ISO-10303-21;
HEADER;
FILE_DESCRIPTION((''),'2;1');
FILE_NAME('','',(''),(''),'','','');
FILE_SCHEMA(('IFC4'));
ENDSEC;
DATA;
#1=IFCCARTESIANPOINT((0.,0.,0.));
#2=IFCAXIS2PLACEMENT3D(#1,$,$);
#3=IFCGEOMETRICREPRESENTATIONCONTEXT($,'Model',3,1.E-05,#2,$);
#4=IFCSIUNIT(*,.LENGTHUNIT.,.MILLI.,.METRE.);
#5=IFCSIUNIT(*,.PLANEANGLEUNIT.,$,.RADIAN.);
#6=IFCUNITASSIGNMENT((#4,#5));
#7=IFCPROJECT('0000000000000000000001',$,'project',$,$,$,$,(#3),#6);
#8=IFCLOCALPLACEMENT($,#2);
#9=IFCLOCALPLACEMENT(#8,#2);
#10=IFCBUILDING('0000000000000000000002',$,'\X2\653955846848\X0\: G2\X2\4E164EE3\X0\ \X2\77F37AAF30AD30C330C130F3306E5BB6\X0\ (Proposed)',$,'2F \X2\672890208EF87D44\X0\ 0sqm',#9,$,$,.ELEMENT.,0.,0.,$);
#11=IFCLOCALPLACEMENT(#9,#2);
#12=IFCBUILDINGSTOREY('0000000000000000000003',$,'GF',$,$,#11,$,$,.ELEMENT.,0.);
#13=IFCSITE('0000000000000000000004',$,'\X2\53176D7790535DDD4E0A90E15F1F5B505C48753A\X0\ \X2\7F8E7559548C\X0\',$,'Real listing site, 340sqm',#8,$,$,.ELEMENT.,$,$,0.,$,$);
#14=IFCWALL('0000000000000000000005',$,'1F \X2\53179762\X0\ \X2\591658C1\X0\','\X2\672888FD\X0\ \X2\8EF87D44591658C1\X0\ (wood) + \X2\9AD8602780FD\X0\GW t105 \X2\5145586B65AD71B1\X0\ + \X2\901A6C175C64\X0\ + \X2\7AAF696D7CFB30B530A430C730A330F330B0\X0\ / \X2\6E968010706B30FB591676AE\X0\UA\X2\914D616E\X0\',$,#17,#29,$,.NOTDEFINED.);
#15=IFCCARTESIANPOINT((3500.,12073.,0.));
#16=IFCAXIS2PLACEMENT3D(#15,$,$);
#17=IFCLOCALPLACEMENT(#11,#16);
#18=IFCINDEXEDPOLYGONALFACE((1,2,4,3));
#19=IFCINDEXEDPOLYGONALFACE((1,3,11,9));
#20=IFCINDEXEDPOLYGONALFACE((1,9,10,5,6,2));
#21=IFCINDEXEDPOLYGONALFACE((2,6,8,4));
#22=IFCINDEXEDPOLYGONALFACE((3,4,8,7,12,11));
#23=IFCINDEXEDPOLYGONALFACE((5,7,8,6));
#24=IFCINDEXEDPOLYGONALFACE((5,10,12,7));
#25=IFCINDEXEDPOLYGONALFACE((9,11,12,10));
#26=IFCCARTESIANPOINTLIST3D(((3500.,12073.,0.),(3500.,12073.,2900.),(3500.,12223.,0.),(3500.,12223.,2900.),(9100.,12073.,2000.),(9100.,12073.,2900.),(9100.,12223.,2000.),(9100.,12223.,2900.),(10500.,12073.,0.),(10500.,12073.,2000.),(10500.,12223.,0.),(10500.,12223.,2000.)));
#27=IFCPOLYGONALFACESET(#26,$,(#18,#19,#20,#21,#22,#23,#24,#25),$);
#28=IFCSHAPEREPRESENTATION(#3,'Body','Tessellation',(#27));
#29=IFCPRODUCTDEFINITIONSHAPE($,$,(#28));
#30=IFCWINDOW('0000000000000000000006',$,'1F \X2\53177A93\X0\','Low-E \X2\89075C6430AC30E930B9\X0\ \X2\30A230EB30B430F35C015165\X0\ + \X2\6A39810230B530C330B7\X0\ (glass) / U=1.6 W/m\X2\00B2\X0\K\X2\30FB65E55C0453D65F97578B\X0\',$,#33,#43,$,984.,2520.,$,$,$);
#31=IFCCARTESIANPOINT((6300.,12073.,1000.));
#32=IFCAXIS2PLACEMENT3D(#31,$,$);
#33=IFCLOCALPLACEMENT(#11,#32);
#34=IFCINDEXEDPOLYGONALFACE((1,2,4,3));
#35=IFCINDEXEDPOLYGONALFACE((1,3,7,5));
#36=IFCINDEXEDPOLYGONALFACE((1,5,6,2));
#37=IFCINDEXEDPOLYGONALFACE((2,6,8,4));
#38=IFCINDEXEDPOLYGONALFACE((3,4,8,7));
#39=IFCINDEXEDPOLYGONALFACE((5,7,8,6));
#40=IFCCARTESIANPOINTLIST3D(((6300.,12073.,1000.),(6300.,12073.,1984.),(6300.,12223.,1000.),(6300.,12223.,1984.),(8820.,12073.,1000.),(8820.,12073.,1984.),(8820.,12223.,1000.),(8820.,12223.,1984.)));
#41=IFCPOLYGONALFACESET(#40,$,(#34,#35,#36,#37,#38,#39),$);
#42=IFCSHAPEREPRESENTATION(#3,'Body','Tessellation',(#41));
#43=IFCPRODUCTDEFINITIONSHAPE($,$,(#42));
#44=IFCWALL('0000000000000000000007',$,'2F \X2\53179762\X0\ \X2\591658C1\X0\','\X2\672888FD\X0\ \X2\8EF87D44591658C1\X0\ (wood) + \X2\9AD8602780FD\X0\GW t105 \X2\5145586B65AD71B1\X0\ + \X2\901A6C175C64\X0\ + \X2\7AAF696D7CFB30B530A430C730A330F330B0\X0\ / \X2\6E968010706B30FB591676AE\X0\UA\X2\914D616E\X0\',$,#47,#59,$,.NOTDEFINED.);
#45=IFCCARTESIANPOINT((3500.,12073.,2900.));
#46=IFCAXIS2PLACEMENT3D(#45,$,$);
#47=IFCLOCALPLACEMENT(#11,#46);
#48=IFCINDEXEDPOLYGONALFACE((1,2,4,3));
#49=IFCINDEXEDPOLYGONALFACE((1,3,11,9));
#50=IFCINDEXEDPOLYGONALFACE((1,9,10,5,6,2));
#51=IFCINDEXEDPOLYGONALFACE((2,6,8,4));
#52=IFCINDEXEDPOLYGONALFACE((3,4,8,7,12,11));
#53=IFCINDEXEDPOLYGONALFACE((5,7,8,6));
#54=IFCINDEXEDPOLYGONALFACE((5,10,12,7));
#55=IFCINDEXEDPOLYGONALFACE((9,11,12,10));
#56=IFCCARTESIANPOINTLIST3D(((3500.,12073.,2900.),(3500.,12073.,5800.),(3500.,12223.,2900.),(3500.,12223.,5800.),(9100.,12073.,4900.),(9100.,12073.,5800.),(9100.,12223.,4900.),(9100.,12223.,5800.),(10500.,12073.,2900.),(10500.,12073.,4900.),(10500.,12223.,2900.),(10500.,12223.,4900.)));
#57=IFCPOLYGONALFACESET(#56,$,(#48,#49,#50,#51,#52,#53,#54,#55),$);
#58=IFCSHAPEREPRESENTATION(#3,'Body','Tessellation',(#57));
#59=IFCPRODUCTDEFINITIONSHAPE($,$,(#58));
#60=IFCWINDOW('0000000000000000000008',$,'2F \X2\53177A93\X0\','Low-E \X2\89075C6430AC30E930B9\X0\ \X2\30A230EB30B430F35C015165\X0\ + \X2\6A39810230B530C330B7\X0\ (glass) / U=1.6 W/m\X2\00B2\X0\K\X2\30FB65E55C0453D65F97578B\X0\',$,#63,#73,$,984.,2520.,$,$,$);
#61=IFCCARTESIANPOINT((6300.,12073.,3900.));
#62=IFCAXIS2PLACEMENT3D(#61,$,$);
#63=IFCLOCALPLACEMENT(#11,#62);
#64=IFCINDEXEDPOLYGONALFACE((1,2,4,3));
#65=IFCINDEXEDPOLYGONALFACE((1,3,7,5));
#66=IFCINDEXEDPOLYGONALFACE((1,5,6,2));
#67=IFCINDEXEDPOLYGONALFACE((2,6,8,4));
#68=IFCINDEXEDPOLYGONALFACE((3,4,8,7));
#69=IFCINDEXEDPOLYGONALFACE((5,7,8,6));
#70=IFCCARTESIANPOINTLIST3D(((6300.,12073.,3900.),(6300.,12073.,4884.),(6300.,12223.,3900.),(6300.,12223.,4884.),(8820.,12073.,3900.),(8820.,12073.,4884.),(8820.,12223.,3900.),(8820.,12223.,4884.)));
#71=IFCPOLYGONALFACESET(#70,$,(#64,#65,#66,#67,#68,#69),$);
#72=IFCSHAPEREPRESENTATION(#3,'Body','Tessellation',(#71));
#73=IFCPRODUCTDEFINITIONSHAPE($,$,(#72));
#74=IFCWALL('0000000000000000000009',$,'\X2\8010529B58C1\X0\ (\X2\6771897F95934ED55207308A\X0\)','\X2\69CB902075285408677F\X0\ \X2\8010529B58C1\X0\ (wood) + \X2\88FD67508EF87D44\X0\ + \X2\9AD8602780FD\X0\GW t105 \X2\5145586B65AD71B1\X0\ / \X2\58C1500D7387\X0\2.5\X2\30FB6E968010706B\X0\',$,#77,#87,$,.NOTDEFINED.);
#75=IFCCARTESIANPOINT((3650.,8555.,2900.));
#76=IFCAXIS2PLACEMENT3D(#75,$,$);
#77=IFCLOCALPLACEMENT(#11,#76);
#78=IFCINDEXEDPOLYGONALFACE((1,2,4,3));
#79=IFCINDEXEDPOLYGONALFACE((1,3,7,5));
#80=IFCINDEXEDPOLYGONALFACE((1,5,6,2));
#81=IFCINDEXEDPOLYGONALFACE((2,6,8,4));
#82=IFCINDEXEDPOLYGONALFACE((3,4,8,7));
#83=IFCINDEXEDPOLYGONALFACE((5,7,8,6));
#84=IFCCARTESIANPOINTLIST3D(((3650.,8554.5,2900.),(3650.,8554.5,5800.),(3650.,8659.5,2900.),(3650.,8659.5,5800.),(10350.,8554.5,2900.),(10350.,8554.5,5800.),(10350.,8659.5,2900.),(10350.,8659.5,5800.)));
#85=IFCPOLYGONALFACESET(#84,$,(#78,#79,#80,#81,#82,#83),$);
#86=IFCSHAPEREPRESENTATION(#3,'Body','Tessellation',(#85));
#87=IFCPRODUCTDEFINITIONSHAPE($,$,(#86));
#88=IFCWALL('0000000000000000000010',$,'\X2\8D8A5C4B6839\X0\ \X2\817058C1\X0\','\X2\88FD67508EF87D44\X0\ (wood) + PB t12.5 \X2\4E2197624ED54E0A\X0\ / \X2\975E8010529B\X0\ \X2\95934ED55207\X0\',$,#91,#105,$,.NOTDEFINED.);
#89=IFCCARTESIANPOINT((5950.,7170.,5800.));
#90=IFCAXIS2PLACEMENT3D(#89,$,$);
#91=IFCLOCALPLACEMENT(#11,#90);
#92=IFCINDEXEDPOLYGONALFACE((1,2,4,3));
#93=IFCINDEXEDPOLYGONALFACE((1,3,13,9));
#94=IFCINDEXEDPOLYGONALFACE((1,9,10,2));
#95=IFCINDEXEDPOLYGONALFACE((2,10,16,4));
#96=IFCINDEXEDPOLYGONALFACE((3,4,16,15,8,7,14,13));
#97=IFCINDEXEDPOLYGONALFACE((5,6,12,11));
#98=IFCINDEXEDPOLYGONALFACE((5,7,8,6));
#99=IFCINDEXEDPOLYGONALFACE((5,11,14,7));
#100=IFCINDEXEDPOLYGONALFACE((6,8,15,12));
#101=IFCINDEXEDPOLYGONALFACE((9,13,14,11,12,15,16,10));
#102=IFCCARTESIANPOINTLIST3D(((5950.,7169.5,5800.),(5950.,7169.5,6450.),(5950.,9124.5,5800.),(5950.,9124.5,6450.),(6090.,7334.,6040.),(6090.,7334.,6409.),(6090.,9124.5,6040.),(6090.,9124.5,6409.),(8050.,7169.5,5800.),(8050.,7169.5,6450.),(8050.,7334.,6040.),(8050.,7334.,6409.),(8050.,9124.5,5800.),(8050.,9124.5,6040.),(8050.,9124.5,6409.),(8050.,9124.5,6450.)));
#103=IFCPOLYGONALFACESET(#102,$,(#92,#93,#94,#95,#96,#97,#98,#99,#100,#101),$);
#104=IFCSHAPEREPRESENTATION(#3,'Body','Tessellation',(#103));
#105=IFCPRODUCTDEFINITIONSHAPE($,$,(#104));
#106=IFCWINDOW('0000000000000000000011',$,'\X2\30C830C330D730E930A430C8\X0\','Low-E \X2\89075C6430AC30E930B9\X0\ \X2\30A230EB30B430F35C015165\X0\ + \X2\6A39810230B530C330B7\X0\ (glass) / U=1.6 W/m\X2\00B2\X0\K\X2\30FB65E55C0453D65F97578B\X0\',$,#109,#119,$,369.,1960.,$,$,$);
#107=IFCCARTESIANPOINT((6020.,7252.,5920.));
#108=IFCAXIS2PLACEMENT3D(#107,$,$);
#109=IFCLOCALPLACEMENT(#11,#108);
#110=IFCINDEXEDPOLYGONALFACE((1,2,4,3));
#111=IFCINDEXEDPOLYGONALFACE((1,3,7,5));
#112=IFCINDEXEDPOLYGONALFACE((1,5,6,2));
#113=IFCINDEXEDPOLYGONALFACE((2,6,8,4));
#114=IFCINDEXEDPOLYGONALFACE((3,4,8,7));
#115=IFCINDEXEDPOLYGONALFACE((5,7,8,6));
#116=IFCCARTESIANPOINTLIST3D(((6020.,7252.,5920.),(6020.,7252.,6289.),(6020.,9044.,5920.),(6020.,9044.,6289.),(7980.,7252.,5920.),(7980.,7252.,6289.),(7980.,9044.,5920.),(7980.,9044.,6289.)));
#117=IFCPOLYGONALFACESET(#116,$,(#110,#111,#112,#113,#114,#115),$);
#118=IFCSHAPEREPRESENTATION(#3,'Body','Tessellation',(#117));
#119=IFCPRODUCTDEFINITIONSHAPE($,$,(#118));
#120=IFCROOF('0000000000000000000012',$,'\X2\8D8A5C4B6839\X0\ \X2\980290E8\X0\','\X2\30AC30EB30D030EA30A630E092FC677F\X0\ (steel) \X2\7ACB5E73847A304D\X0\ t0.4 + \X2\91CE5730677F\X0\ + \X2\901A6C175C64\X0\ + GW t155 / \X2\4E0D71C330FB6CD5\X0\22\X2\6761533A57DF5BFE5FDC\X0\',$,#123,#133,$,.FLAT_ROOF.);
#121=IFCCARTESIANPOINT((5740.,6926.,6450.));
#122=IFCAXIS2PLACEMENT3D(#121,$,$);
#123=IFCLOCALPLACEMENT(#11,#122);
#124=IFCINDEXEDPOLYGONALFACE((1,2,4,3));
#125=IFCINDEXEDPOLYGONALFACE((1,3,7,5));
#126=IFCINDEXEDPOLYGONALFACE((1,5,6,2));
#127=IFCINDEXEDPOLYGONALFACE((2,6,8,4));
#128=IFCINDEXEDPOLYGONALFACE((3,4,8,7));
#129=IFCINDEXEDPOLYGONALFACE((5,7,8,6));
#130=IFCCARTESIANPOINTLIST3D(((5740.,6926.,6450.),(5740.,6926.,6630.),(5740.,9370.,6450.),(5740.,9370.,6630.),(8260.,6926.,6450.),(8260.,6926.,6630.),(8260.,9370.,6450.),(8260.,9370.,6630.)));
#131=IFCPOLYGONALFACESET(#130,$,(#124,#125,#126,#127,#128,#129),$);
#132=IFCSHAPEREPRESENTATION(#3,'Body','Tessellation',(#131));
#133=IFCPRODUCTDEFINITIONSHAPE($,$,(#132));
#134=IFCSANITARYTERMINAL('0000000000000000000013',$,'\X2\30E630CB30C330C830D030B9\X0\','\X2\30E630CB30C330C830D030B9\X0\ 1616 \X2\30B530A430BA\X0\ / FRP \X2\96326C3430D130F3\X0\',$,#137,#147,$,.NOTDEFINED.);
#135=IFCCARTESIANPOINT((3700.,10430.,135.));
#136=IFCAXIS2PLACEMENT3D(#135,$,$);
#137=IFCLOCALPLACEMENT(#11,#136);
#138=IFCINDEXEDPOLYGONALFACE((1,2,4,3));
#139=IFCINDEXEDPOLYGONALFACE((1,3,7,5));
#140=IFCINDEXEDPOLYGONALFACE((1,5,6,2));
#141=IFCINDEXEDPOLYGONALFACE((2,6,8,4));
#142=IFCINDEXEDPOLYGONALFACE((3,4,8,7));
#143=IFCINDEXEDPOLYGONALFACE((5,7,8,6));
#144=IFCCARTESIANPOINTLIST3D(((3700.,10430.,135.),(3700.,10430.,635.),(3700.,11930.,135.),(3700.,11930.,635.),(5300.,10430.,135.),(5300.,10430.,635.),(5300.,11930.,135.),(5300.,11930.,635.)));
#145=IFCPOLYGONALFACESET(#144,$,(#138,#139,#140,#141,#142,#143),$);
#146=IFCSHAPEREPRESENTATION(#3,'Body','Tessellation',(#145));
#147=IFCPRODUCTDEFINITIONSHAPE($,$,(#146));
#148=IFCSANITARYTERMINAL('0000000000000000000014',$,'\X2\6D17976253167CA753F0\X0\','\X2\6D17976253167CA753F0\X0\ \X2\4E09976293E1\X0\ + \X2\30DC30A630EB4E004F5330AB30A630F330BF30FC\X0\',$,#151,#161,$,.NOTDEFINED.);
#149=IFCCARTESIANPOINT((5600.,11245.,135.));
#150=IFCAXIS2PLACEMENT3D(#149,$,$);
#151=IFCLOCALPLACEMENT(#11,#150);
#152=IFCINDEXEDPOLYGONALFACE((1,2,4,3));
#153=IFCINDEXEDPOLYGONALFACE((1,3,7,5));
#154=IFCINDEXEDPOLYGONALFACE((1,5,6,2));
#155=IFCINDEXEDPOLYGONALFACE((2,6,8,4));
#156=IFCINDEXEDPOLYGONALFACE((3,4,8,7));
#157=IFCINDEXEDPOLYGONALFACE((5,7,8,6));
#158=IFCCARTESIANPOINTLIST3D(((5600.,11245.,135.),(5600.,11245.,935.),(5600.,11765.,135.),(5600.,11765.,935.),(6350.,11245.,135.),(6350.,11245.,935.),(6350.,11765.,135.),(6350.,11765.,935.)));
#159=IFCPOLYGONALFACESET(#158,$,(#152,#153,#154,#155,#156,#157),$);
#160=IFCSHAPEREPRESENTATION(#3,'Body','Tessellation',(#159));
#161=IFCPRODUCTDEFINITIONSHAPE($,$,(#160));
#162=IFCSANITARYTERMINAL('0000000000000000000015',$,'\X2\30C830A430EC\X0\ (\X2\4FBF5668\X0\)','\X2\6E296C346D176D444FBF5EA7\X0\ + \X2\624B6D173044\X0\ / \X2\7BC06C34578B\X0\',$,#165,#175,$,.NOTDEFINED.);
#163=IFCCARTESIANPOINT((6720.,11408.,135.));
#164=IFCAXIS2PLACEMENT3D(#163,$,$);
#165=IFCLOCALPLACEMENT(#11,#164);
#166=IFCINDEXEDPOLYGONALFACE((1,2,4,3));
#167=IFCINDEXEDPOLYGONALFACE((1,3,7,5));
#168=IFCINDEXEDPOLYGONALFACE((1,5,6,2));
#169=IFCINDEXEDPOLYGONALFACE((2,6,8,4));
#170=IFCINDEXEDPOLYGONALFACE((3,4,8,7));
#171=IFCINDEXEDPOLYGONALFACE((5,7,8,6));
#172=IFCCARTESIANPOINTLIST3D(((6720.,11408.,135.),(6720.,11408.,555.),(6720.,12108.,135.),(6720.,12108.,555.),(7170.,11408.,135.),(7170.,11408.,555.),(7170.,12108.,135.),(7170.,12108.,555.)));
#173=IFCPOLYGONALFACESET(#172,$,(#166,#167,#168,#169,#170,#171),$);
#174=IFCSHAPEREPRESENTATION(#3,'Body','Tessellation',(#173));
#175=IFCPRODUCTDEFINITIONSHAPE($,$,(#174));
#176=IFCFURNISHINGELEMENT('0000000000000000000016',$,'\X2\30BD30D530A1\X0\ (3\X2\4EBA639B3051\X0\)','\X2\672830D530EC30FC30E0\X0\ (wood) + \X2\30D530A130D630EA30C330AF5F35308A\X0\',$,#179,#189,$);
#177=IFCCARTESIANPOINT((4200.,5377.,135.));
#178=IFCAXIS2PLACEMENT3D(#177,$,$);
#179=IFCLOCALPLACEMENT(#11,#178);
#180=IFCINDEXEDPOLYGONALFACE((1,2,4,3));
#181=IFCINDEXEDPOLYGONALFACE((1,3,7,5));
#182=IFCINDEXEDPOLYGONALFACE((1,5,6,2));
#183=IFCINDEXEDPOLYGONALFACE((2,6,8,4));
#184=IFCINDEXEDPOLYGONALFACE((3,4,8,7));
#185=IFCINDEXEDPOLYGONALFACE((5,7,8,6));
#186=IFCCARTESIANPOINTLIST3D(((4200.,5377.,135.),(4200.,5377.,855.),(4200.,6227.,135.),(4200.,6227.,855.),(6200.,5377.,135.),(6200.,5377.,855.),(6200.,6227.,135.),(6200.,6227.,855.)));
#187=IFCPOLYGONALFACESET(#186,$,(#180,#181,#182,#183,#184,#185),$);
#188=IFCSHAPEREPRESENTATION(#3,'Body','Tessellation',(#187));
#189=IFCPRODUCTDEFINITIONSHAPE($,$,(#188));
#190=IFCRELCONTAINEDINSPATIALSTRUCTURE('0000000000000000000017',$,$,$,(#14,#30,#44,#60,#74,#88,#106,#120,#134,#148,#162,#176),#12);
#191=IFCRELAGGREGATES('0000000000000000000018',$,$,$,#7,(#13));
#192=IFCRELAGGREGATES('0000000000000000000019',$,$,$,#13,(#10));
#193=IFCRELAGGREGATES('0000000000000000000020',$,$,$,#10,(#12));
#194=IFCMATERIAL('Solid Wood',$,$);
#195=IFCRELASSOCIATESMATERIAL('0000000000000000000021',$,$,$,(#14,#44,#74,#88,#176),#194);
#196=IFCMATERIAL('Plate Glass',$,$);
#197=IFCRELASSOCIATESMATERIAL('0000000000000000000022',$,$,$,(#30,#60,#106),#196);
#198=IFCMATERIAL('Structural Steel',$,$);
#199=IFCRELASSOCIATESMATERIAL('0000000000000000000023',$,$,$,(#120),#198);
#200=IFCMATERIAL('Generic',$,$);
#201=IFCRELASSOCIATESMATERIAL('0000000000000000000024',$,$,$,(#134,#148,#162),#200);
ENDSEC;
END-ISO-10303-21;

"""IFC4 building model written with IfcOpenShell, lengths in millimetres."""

from ifc_helpers import new_model, si_unit, frame, frame_2d, origin, place, context, project, spatial, rectangle, extrude, material, element, fill, save


model = new_model("IFC4")

# Units and contexts
model_context = context("Model", 3, precision=1e-05, world=origin())
ifc_project = project(units=[si_unit("LENGTHUNIT", "METRE", prefix="MILLI"), si_unit("PLANEANGLEUNIT", "RADIAN")], contexts=[model_context])

# Site, building, storey
site_placement = place(None, origin())
site = spatial("IfcSite", under=ifc_project, at=site_placement, Name="北海道川上郡弟子屈町 美留和", ObjectType="Real listing site, 340sqm", CompositionType="ELEMENT", RefElevation=0.0)
building_placement = place(site_placement, origin())
building = spatial("IfcBuilding", under=site, at=building_placement, Name="改善案: G2世代 石窯キッチンの家 (Proposed)", ObjectType="2F 木造軸組 0sqm", CompositionType="ELEMENT", ElevationOfRefHeight=0.0, ElevationOfTerrain=0.0)
storey_placement = place(building_placement, origin())
storey = spatial("IfcBuildingStorey", under=building, at=storey_placement, Name="GF", CompositionType="ELEMENT", Elevation=0.0)

# Wall, opening, window
ifc_material_1 = material(Name="Solid Wood")
wall_1_placement = place(storey_placement, frame((3500.0, 12073.0, 0.0)))
wall_1 = element("IfcWall", 1, at=wall_1_placement, inside=storey, material=ifc_material_1, Name="1F 北面 外壁", Description="木製 軸組外壁 (wood) + 高性能GW t105 充填断熱 + 通気層 + 窯業系サイディング / 準耐火・外皮UA配慮", PredefinedType="NOTDEFINED", context=model_context, shape_type="SweptSolid", body=[
    extrude(rectangle(XDim=7000.0, YDim=150.0, at=frame_2d((3500.0, 75.0))), frame((3500.0, 12073.0, 0.0)), (0.0, 0.0, 1.0), 2900.0),
])
opening_1_placement = place(storey_placement, frame((6300.0, 12073.0, 1000.0)))
opening_1 = element("IfcOpeningElement", 2, at=opening_1_placement, cuts=wall_1, PredefinedType="NOTDEFINED", context=model_context, shape_type="SweptSolid", body=[
    extrude(rectangle(XDim=2520.0, YDim=150.0, at=frame_2d((1260.0, 75.0))), frame((6300.0, 12073.0, 1000.0)), (0.0, 0.0, 1.0), 984.0),
])
ifc_material_2 = material(Name="Plate Glass")
window_1_placement = place(storey_placement, frame((6300.0, 12073.0, 1000.0)))
window_1 = element("IfcWindow", 3, at=window_1_placement, inside=storey, material=ifc_material_2, Name="1F 北窓", Description="Low-E 複層ガラス アルゴン封入 + 樹脂サッシ (glass) / U=1.6 W/m²K・日射取得型", OverallHeight=984.0, OverallWidth=2520.0, context=model_context, shape_type="SweptSolid", body=[
    extrude(rectangle(XDim=2520.0, YDim=150.0, at=frame_2d((1260.0, 75.0))), frame((6300.0, 12073.0, 1000.0)), (0.0, 0.0, 1.0), 984.0),
])
fill(opening_1, window_1)

# Wall, opening, window
wall_2_placement = place(storey_placement, frame((3500.0, 12073.0, 2900.0)))
wall_2 = element("IfcWall", 4, at=wall_2_placement, inside=storey, material=ifc_material_1, Name="2F 北面 外壁", Description="木製 軸組外壁 (wood) + 高性能GW t105 充填断熱 + 通気層 + 窯業系サイディング / 準耐火・外皮UA配慮", PredefinedType="NOTDEFINED", context=model_context, shape_type="SweptSolid", body=[
    extrude(rectangle(XDim=7000.0, YDim=150.0, at=frame_2d((3500.0, 75.0))), frame((3500.0, 12073.0, 2900.0)), (0.0, 0.0, 1.0), 2900.0),
])
opening_2_placement = place(storey_placement, frame((6300.0, 12073.0, 3900.0)))
opening_2 = element("IfcOpeningElement", 5, at=opening_2_placement, cuts=wall_2, PredefinedType="NOTDEFINED", context=model_context, shape_type="SweptSolid", body=[
    extrude(rectangle(XDim=2520.0, YDim=150.0, at=frame_2d((1260.0, 75.0))), frame((6300.0, 12073.0, 3900.0)), (0.0, 0.0, 1.0), 984.0),
])
window_2_placement = place(storey_placement, frame((6300.0, 12073.0, 3900.0)))
window_2 = element("IfcWindow", 6, at=window_2_placement, inside=storey, material=ifc_material_2, Name="2F 北窓", Description="Low-E 複層ガラス アルゴン封入 + 樹脂サッシ (glass) / U=1.6 W/m²K・日射取得型", OverallHeight=984.0, OverallWidth=2520.0, context=model_context, shape_type="SweptSolid", body=[
    extrude(rectangle(XDim=2520.0, YDim=150.0, at=frame_2d((1260.0, 75.0))), frame((6300.0, 12073.0, 3900.0)), (0.0, 0.0, 1.0), 984.0),
])
fill(opening_2, window_2)

# Wall
wall_3_placement = place(storey_placement, frame((3650.0, 8555.0, 2900.0)))
element("IfcWall", 7, at=wall_3_placement, inside=storey, material=ifc_material_1, Name="耐力壁 (東西間仕切り)", Description="構造用合板 耐力壁 (wood) + 製材軸組 + 高性能GW t105 充填断熱 / 壁倍率2.5・準耐火", PredefinedType="NOTDEFINED", context=model_context, shape_type="SweptSolid", body=[
    extrude(rectangle(XDim=6700.0, YDim=105.0, at=frame_2d((3350.0, 52.0))), frame((3650.0, 8555.0, 2900.0)), (0.0, 0.0, 1.0), 2900.0),
])

# Wall, opening, window
wall_4_placement = place(storey_placement, frame((5950.0, 7170.0, 5800.0)))
wall_4 = element("IfcWall", 8, at=wall_4_placement, inside=storey, material=ifc_material_1, Name="越屋根 腰壁", Description="製材軸組 (wood) + PB t12.5 両面仕上 / 非耐力 間仕切", PredefinedType="NOTDEFINED", context=model_context, shape_type="SweptSolid", body=[
    extrude(rectangle(XDim=2100.0, YDim=1955.0, at=frame_2d((1050.0, 977.0))), frame((5950.0, 7170.0, 5800.0)), (0.0, 0.0, 1.0), 650.0),
])
opening_3_placement = place(storey_placement, frame((6020.0, 7252.0, 5920.0)))
opening_3 = element("IfcOpeningElement", 9, at=opening_3_placement, cuts=wall_4, PredefinedType="NOTDEFINED", context=model_context, shape_type="SweptSolid", body=[
    extrude(rectangle(XDim=1960.0, YDim=1792.0, at=frame_2d((980.0, 896.0))), frame((6020.0, 7252.0, 5920.0)), (0.0, 0.0, 1.0), 369.0),
])
window_3_placement = place(storey_placement, frame((6020.0, 7252.0, 5920.0)))
window_3 = element("IfcWindow", 10, at=window_3_placement, inside=storey, material=ifc_material_2, Name="トップライト", Description="Low-E 複層ガラス アルゴン封入 + 樹脂サッシ (glass) / U=1.6 W/m²K・日射取得型", OverallHeight=369.0, OverallWidth=1960.0, context=model_context, shape_type="SweptSolid", body=[
    extrude(rectangle(XDim=1960.0, YDim=1792.0, at=frame_2d((980.0, 896.0))), frame((6020.0, 7252.0, 5920.0)), (0.0, 0.0, 1.0), 369.0),
])
fill(opening_3, window_3)

# Roof
ifc_material_3 = material(Name="Structural Steel")
roof_placement = place(storey_placement, frame((5740.0, 6926.0, 6450.0)))
element("IfcRoof", 11, at=roof_placement, inside=storey, material=ifc_material_3, Name="越屋根 頂部", Description="ガルバリウム鋼板 (steel) 立平葺き t0.4 + 野地板 + 通気層 + GW t155 / 不燃・法22条区域対応", PredefinedType="FLAT_ROOF", context=model_context, shape_type="SweptSolid", body=[
    extrude(rectangle(XDim=2520.0, YDim=2444.0, at=frame_2d((1260.0, 1222.0))), frame((5740.0, 6926.0, 6450.0)), (0.0, 0.0, 1.0), 180.0),
])

# Sanitary terminals
ifc_material_4 = material(Name="Generic")
sanitary_terminal_1_placement = place(storey_placement, frame((3700.0, 10430.0, 135.0)))
element("IfcSanitaryTerminal", 12, at=sanitary_terminal_1_placement, inside=storey, material=ifc_material_4, Name="ユニットバス", Description="ユニットバス 1616 サイズ / FRP 防水パン", PredefinedType="NOTDEFINED", context=model_context, shape_type="SweptSolid", body=[
    extrude(rectangle(XDim=1600.0, YDim=1500.0, at=frame_2d((800.0, 750.0))), frame((3700.0, 10430.0, 135.0)), (0.0, 0.0, 1.0), 500.0),
])
sanitary_terminal_2_placement = place(storey_placement, frame((5600.0, 11245.0, 135.0)))
element("IfcSanitaryTerminal", 13, at=sanitary_terminal_2_placement, inside=storey, material=ifc_material_4, Name="洗面化粧台", Description="洗面化粧台 三面鏡 + ボウル一体カウンター", PredefinedType="NOTDEFINED", context=model_context, shape_type="SweptSolid", body=[
    extrude(rectangle(XDim=750.0, YDim=520.0, at=frame_2d((375.0, 260.0))), frame((5600.0, 11245.0, 135.0)), (0.0, 0.0, 1.0), 800.0),
])
sanitary_terminal_3_placement = place(storey_placement, frame((6720.0, 11408.0, 135.0)))
element("IfcSanitaryTerminal", 14, at=sanitary_terminal_3_placement, inside=storey, material=ifc_material_4, Name="トイレ (便器)", Description="温水洗浄便座 + 手洗い / 節水型", PredefinedType="NOTDEFINED", context=model_context, shape_type="SweptSolid", body=[
    extrude(rectangle(XDim=450.0, YDim=700.0, at=frame_2d((225.0, 350.0))), frame((6720.0, 11408.0, 135.0)), (0.0, 0.0, 1.0), 420.0),
])

# Furnishing element
furnishing_1_placement = place(storey_placement, frame((4200.0, 5377.0, 135.0)))
element("IfcFurnishingElement", 15, at=furnishing_1_placement, inside=storey, material=ifc_material_1, Name="ソファ (3人掛け)", Description="木フレーム (wood) + ファブリック張り", context=model_context, shape_type="SweptSolid", body=[
    extrude(rectangle(XDim=2000.0, YDim=850.0, at=frame_2d((1000.0, 425.0))), frame((4200.0, 5377.0, 135.0)), (0.0, 0.0, 1.0), 720.0),
])

save(model, "model.ifc")
